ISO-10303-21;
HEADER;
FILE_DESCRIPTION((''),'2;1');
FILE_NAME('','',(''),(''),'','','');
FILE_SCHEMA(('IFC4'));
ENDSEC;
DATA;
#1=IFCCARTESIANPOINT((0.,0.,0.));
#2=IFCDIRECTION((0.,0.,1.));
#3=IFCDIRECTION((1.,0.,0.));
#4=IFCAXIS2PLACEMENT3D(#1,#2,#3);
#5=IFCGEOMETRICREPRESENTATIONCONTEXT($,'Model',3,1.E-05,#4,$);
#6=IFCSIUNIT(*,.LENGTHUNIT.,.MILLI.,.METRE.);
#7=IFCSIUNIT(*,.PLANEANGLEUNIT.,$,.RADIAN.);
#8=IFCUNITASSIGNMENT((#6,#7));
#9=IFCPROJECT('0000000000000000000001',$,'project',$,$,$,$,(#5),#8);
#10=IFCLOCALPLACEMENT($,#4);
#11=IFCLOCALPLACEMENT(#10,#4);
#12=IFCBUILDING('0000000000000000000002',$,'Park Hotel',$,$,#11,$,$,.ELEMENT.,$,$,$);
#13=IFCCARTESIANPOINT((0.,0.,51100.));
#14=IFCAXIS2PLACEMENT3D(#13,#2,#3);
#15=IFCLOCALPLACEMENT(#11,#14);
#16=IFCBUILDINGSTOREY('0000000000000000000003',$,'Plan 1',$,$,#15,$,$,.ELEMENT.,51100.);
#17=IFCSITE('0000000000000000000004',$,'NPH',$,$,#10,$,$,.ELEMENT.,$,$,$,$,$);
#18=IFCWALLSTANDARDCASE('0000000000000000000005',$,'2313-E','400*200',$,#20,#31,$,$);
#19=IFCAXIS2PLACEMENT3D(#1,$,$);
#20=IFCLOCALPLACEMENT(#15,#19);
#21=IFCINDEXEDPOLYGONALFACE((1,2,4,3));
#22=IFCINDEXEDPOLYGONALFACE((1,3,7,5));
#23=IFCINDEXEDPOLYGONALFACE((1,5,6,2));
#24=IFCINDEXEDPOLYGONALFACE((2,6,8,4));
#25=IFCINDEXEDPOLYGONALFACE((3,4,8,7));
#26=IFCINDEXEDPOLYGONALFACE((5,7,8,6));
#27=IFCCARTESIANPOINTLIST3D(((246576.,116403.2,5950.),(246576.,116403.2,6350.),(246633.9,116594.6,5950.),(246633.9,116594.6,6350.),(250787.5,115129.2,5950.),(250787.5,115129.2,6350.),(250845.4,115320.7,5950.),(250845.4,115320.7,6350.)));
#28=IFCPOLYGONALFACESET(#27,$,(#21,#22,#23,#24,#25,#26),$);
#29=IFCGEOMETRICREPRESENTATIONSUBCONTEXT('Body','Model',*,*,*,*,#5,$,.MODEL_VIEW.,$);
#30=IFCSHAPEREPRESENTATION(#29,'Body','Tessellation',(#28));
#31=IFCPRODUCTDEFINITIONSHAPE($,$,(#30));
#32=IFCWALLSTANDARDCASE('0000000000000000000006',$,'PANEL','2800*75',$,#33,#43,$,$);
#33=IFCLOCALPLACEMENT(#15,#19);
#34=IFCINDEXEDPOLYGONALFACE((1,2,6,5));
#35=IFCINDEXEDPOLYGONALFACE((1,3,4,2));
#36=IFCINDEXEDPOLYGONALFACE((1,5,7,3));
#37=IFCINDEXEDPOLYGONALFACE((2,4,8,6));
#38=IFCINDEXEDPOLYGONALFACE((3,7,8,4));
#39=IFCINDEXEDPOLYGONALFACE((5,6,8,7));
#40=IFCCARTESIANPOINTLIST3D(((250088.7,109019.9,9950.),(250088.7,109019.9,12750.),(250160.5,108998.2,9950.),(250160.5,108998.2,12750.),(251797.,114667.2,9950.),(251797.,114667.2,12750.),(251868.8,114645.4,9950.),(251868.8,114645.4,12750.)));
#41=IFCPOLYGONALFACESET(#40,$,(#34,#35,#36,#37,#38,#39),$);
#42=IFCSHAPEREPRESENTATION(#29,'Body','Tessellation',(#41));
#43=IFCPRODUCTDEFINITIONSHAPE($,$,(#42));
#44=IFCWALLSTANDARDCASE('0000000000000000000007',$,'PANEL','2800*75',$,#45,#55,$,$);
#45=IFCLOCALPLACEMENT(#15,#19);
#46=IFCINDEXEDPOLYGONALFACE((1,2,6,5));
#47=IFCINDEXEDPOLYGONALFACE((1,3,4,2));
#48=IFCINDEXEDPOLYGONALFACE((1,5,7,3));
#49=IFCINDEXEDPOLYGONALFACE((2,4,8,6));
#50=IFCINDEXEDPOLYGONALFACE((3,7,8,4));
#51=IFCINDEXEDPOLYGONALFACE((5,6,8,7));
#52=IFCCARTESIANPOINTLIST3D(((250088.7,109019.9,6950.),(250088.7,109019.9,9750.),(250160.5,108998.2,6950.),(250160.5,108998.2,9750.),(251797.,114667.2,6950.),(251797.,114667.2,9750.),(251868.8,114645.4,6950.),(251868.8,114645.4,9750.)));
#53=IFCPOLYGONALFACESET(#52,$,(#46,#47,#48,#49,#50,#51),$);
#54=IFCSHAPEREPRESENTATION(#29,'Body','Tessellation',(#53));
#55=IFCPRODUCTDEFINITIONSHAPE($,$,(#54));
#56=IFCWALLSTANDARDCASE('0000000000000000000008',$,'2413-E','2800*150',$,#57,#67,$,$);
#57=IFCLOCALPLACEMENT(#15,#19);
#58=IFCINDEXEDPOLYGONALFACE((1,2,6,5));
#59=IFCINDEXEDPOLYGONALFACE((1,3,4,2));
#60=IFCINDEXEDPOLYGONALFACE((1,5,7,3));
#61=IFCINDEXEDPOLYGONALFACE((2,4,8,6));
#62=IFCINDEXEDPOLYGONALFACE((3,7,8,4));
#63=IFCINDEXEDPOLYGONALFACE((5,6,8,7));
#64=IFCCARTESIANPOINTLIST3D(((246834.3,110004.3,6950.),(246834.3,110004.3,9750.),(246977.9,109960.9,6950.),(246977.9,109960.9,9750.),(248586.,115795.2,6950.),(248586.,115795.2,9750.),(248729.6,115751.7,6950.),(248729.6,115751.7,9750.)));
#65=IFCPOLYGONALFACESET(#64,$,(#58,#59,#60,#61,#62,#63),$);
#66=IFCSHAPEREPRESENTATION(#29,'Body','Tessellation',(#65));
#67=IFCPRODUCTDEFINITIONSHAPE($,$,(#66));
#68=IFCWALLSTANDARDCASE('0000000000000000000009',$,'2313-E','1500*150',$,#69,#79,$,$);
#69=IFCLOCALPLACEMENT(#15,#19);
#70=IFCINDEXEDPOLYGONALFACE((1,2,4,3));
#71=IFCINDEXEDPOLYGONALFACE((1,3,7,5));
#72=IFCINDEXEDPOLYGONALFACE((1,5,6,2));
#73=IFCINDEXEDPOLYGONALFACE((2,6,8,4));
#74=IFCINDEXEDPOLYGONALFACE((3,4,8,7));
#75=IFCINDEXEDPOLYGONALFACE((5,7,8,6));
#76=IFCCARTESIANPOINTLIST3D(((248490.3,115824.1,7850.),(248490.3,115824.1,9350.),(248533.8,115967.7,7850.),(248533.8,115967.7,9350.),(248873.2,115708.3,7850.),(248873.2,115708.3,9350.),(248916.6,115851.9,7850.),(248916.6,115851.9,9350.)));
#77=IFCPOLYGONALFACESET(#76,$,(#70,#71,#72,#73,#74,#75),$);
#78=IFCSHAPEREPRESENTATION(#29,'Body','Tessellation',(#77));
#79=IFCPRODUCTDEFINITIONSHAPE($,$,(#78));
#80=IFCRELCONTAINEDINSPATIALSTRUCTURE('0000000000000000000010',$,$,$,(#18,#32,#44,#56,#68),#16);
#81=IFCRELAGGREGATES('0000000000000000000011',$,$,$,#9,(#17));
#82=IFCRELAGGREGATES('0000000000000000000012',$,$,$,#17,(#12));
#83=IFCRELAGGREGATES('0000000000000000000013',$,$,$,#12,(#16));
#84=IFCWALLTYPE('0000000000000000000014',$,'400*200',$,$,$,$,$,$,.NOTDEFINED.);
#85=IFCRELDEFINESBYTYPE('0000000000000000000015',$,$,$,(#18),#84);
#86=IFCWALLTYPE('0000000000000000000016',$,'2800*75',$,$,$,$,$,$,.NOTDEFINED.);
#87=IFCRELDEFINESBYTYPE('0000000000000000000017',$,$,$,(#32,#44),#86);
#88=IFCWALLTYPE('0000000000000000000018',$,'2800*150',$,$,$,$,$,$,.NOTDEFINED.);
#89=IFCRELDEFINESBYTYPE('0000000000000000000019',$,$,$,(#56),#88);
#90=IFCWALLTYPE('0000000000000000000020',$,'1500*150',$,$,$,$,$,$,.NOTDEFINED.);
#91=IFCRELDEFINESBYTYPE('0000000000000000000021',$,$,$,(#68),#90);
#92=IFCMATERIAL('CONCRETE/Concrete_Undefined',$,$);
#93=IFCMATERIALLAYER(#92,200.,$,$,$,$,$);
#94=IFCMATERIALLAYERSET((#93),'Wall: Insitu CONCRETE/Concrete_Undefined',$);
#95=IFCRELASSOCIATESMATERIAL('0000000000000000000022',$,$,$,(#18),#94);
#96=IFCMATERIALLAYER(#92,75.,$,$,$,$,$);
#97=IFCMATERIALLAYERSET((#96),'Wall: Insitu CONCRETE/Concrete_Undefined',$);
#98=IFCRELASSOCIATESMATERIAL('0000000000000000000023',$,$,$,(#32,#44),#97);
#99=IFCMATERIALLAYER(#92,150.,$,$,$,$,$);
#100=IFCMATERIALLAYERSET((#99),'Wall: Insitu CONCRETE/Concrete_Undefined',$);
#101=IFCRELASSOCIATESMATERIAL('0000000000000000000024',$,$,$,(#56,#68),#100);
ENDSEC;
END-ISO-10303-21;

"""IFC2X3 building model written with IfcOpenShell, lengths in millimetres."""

from ifc_helpers import new_model, si_unit, frame, frame_2d, origin_with_axes, place, context, subcontext, project, spatial, rectangle, extrude, material, layer, layer_set, layer_usage, type_object, element, save


model = new_model("IFC2X3")

# Units and contexts
model_context = context("Model", 3, precision=1e-05, world=origin_with_axes())
body_context = subcontext(model_context, "Body", "Model", "MODEL_VIEW")
ifc_project = project(units=[si_unit("LENGTHUNIT", "METRE", prefix="MILLI"), si_unit("PLANEANGLEUNIT", "RADIAN")], contexts=[model_context])

# Site, building, storey
site_placement = place(None, origin_with_axes())
site = spatial("IfcSite", under=ifc_project, at=site_placement, Name="NPH", CompositionType="ELEMENT")
building_placement = place(site_placement, origin_with_axes())
building = spatial("IfcBuilding", under=site, at=building_placement, Name="Park Hotel", CompositionType="ELEMENT")
storey_placement = place(building_placement, frame((0.0, 0.0, 51100.0), z_axis=(0.0, 0.0, 1.0), x_axis=(1.0, 0.0, 0.0)))
storey = spatial("IfcBuildingStorey", under=building, at=storey_placement, Name="Plan 1", CompositionType="ELEMENT", Elevation=51100.0)

# Walls
ifc_material_1 = material(Name="CONCRETE/Concrete_Undefined")
ifc_layer_1 = layer(ifc_material_1, 200.0)
ifc_layer_set_1 = layer_set([ifc_layer_1], Name="Wall: Insitu CONCRETE/Concrete_Undefined")
ifc_layer_usage_1 = layer_usage(ifc_layer_set_1, "AXIS2", "POSITIVE", -100.0)
wall_type_1 = type_object("IfcWallType", Name="400*200", PredefinedType="NOTDEFINED")
wall_1_placement = place(storey_placement, frame((246605.0, 116498.9, 5950.0), z_axis=(0.0, 0.0, 1.0), x_axis=(0.957166, -0.289539, 0.0)))
element("IfcWallStandardCase", 1, at=wall_1_placement, inside=storey, type_object=wall_type_1, material=ifc_layer_usage_1, Name="2313-E", Description="400*200", context=body_context, shape_type="SweptSolid", body=[
    extrude(rectangle(XDim=4400.0, YDim=200.0, at=frame_2d((0.0, 2200.0), x_axis=(0.0, -1.0))), frame((0.0, 0.0, 0.0), z_axis=(0.0, 0.0, 1.0), x_axis=(0.0, -1.0, 0.0)), (0.0, 0.0, 1.0), 400.0),
])
ifc_layer_2 = layer(ifc_material_1, 75.0)
ifc_layer_set_2 = layer_set([ifc_layer_2], Name="Wall: Insitu CONCRETE/Concrete_Undefined")
ifc_layer_usage_2 = layer_usage(ifc_layer_set_2, "AXIS2", "POSITIVE", -37.5)
wall_type_2 = type_object("IfcWallType", Name="2800*75", PredefinedType="NOTDEFINED")
wall_2_placement = place(storey_placement, frame((250124.6, 109009.0, 9950.0), z_axis=(0.0, 0.0, 1.0), x_axis=(0.289539, 0.957166, 0.0)))
element("IfcWallStandardCase", 2, at=wall_2_placement, inside=storey, type_object=wall_type_2, material=ifc_layer_usage_2, Name="PANEL", Description="2800*75", context=body_context, shape_type="SweptSolid", body=[
    extrude(rectangle(XDim=5900.0, YDim=75.0, at=frame_2d((0.0, 2950.0), x_axis=(0.0, -1.0))), frame((0.0, 0.0, 0.0), z_axis=(0.0, 0.0, 1.0), x_axis=(0.0, -1.0, 0.0)), (0.0, 0.0, 1.0), 2800.0),
])
ifc_layer_usage_3 = layer_usage(ifc_layer_set_2, "AXIS2", "POSITIVE", -37.5)
wall_3_placement = place(storey_placement, frame((250124.6, 109009.0, 6950.0), z_axis=(0.0, 0.0, 1.0), x_axis=(0.289539, 0.957166, 0.0)))
element("IfcWallStandardCase", 3, at=wall_3_placement, inside=storey, type_object=wall_type_2, material=ifc_layer_usage_3, Name="PANEL", Description="2800*75", context=body_context, shape_type="SweptSolid", body=[
    extrude(rectangle(XDim=5900.0, YDim=75.0, at=frame_2d((0.0, 2950.0), x_axis=(0.0, -1.0))), frame((0.0, 0.0, 0.0), z_axis=(0.0, 0.0, 1.0), x_axis=(0.0, -1.0, 0.0)), (0.0, 0.0, 1.0), 2800.0),
])
ifc_layer_3 = layer(ifc_material_1, 150.0)
ifc_layer_set_3 = layer_set([ifc_layer_3], Name="Wall: Insitu CONCRETE/Concrete_Undefined")
ifc_layer_usage_4 = layer_usage(ifc_layer_set_3, "AXIS2", "POSITIVE", -75.0)
wall_type_3 = type_object("IfcWallType", Name="2800*150", PredefinedType="NOTDEFINED")
wall_4_placement = place(storey_placement, frame((246906.1, 109982.6, 6950.0), z_axis=(0.0, 0.0, 1.0), x_axis=(0.289537, 0.957167, 0.0)))
element("IfcWallStandardCase", 4, at=wall_4_placement, inside=storey, type_object=wall_type_3, material=ifc_layer_usage_4, Name="2413-E", Description="2800*150", context=body_context, shape_type="SweptSolid", body=[
    extrude(rectangle(XDim=6050.0, YDim=150.0, at=frame_2d((0.0, 3025.0), x_axis=(0.0, -1.0))), frame((0.0, 0.0, 0.0), z_axis=(0.0, 0.0, 1.0), x_axis=(0.0, -1.0, 0.0)), (0.0, 0.0, 1.0), 2800.0),
])
ifc_layer_usage_5 = layer_usage(ifc_layer_set_3, "AXIS2", "POSITIVE", -75.0)
wall_type_4 = type_object("IfcWallType", Name="1500*150", PredefinedType="NOTDEFINED")
wall_5_placement = place(storey_placement, frame((248512.1, 115895.9, 7850.0), z_axis=(0.0, 0.0, 1.0), x_axis=(0.957161, -0.289556, 0.0)))
element("IfcWallStandardCase", 5, at=wall_5_placement, inside=storey, type_object=wall_type_4, material=ifc_layer_usage_5, Name="2313-E", Description="1500*150", context=body_context, shape_type="SweptSolid", body=[
    extrude(rectangle(XDim=400.0, YDim=150.0, at=frame_2d((0.0, 200.0), x_axis=(0.0, -1.0))), frame((0.0, 0.0, 0.0), z_axis=(0.0, 0.0, 1.0), x_axis=(0.0, -1.0, 0.0)), (0.0, 0.0, 1.0), 1500.0),
])

save(model, "model.ifc")
